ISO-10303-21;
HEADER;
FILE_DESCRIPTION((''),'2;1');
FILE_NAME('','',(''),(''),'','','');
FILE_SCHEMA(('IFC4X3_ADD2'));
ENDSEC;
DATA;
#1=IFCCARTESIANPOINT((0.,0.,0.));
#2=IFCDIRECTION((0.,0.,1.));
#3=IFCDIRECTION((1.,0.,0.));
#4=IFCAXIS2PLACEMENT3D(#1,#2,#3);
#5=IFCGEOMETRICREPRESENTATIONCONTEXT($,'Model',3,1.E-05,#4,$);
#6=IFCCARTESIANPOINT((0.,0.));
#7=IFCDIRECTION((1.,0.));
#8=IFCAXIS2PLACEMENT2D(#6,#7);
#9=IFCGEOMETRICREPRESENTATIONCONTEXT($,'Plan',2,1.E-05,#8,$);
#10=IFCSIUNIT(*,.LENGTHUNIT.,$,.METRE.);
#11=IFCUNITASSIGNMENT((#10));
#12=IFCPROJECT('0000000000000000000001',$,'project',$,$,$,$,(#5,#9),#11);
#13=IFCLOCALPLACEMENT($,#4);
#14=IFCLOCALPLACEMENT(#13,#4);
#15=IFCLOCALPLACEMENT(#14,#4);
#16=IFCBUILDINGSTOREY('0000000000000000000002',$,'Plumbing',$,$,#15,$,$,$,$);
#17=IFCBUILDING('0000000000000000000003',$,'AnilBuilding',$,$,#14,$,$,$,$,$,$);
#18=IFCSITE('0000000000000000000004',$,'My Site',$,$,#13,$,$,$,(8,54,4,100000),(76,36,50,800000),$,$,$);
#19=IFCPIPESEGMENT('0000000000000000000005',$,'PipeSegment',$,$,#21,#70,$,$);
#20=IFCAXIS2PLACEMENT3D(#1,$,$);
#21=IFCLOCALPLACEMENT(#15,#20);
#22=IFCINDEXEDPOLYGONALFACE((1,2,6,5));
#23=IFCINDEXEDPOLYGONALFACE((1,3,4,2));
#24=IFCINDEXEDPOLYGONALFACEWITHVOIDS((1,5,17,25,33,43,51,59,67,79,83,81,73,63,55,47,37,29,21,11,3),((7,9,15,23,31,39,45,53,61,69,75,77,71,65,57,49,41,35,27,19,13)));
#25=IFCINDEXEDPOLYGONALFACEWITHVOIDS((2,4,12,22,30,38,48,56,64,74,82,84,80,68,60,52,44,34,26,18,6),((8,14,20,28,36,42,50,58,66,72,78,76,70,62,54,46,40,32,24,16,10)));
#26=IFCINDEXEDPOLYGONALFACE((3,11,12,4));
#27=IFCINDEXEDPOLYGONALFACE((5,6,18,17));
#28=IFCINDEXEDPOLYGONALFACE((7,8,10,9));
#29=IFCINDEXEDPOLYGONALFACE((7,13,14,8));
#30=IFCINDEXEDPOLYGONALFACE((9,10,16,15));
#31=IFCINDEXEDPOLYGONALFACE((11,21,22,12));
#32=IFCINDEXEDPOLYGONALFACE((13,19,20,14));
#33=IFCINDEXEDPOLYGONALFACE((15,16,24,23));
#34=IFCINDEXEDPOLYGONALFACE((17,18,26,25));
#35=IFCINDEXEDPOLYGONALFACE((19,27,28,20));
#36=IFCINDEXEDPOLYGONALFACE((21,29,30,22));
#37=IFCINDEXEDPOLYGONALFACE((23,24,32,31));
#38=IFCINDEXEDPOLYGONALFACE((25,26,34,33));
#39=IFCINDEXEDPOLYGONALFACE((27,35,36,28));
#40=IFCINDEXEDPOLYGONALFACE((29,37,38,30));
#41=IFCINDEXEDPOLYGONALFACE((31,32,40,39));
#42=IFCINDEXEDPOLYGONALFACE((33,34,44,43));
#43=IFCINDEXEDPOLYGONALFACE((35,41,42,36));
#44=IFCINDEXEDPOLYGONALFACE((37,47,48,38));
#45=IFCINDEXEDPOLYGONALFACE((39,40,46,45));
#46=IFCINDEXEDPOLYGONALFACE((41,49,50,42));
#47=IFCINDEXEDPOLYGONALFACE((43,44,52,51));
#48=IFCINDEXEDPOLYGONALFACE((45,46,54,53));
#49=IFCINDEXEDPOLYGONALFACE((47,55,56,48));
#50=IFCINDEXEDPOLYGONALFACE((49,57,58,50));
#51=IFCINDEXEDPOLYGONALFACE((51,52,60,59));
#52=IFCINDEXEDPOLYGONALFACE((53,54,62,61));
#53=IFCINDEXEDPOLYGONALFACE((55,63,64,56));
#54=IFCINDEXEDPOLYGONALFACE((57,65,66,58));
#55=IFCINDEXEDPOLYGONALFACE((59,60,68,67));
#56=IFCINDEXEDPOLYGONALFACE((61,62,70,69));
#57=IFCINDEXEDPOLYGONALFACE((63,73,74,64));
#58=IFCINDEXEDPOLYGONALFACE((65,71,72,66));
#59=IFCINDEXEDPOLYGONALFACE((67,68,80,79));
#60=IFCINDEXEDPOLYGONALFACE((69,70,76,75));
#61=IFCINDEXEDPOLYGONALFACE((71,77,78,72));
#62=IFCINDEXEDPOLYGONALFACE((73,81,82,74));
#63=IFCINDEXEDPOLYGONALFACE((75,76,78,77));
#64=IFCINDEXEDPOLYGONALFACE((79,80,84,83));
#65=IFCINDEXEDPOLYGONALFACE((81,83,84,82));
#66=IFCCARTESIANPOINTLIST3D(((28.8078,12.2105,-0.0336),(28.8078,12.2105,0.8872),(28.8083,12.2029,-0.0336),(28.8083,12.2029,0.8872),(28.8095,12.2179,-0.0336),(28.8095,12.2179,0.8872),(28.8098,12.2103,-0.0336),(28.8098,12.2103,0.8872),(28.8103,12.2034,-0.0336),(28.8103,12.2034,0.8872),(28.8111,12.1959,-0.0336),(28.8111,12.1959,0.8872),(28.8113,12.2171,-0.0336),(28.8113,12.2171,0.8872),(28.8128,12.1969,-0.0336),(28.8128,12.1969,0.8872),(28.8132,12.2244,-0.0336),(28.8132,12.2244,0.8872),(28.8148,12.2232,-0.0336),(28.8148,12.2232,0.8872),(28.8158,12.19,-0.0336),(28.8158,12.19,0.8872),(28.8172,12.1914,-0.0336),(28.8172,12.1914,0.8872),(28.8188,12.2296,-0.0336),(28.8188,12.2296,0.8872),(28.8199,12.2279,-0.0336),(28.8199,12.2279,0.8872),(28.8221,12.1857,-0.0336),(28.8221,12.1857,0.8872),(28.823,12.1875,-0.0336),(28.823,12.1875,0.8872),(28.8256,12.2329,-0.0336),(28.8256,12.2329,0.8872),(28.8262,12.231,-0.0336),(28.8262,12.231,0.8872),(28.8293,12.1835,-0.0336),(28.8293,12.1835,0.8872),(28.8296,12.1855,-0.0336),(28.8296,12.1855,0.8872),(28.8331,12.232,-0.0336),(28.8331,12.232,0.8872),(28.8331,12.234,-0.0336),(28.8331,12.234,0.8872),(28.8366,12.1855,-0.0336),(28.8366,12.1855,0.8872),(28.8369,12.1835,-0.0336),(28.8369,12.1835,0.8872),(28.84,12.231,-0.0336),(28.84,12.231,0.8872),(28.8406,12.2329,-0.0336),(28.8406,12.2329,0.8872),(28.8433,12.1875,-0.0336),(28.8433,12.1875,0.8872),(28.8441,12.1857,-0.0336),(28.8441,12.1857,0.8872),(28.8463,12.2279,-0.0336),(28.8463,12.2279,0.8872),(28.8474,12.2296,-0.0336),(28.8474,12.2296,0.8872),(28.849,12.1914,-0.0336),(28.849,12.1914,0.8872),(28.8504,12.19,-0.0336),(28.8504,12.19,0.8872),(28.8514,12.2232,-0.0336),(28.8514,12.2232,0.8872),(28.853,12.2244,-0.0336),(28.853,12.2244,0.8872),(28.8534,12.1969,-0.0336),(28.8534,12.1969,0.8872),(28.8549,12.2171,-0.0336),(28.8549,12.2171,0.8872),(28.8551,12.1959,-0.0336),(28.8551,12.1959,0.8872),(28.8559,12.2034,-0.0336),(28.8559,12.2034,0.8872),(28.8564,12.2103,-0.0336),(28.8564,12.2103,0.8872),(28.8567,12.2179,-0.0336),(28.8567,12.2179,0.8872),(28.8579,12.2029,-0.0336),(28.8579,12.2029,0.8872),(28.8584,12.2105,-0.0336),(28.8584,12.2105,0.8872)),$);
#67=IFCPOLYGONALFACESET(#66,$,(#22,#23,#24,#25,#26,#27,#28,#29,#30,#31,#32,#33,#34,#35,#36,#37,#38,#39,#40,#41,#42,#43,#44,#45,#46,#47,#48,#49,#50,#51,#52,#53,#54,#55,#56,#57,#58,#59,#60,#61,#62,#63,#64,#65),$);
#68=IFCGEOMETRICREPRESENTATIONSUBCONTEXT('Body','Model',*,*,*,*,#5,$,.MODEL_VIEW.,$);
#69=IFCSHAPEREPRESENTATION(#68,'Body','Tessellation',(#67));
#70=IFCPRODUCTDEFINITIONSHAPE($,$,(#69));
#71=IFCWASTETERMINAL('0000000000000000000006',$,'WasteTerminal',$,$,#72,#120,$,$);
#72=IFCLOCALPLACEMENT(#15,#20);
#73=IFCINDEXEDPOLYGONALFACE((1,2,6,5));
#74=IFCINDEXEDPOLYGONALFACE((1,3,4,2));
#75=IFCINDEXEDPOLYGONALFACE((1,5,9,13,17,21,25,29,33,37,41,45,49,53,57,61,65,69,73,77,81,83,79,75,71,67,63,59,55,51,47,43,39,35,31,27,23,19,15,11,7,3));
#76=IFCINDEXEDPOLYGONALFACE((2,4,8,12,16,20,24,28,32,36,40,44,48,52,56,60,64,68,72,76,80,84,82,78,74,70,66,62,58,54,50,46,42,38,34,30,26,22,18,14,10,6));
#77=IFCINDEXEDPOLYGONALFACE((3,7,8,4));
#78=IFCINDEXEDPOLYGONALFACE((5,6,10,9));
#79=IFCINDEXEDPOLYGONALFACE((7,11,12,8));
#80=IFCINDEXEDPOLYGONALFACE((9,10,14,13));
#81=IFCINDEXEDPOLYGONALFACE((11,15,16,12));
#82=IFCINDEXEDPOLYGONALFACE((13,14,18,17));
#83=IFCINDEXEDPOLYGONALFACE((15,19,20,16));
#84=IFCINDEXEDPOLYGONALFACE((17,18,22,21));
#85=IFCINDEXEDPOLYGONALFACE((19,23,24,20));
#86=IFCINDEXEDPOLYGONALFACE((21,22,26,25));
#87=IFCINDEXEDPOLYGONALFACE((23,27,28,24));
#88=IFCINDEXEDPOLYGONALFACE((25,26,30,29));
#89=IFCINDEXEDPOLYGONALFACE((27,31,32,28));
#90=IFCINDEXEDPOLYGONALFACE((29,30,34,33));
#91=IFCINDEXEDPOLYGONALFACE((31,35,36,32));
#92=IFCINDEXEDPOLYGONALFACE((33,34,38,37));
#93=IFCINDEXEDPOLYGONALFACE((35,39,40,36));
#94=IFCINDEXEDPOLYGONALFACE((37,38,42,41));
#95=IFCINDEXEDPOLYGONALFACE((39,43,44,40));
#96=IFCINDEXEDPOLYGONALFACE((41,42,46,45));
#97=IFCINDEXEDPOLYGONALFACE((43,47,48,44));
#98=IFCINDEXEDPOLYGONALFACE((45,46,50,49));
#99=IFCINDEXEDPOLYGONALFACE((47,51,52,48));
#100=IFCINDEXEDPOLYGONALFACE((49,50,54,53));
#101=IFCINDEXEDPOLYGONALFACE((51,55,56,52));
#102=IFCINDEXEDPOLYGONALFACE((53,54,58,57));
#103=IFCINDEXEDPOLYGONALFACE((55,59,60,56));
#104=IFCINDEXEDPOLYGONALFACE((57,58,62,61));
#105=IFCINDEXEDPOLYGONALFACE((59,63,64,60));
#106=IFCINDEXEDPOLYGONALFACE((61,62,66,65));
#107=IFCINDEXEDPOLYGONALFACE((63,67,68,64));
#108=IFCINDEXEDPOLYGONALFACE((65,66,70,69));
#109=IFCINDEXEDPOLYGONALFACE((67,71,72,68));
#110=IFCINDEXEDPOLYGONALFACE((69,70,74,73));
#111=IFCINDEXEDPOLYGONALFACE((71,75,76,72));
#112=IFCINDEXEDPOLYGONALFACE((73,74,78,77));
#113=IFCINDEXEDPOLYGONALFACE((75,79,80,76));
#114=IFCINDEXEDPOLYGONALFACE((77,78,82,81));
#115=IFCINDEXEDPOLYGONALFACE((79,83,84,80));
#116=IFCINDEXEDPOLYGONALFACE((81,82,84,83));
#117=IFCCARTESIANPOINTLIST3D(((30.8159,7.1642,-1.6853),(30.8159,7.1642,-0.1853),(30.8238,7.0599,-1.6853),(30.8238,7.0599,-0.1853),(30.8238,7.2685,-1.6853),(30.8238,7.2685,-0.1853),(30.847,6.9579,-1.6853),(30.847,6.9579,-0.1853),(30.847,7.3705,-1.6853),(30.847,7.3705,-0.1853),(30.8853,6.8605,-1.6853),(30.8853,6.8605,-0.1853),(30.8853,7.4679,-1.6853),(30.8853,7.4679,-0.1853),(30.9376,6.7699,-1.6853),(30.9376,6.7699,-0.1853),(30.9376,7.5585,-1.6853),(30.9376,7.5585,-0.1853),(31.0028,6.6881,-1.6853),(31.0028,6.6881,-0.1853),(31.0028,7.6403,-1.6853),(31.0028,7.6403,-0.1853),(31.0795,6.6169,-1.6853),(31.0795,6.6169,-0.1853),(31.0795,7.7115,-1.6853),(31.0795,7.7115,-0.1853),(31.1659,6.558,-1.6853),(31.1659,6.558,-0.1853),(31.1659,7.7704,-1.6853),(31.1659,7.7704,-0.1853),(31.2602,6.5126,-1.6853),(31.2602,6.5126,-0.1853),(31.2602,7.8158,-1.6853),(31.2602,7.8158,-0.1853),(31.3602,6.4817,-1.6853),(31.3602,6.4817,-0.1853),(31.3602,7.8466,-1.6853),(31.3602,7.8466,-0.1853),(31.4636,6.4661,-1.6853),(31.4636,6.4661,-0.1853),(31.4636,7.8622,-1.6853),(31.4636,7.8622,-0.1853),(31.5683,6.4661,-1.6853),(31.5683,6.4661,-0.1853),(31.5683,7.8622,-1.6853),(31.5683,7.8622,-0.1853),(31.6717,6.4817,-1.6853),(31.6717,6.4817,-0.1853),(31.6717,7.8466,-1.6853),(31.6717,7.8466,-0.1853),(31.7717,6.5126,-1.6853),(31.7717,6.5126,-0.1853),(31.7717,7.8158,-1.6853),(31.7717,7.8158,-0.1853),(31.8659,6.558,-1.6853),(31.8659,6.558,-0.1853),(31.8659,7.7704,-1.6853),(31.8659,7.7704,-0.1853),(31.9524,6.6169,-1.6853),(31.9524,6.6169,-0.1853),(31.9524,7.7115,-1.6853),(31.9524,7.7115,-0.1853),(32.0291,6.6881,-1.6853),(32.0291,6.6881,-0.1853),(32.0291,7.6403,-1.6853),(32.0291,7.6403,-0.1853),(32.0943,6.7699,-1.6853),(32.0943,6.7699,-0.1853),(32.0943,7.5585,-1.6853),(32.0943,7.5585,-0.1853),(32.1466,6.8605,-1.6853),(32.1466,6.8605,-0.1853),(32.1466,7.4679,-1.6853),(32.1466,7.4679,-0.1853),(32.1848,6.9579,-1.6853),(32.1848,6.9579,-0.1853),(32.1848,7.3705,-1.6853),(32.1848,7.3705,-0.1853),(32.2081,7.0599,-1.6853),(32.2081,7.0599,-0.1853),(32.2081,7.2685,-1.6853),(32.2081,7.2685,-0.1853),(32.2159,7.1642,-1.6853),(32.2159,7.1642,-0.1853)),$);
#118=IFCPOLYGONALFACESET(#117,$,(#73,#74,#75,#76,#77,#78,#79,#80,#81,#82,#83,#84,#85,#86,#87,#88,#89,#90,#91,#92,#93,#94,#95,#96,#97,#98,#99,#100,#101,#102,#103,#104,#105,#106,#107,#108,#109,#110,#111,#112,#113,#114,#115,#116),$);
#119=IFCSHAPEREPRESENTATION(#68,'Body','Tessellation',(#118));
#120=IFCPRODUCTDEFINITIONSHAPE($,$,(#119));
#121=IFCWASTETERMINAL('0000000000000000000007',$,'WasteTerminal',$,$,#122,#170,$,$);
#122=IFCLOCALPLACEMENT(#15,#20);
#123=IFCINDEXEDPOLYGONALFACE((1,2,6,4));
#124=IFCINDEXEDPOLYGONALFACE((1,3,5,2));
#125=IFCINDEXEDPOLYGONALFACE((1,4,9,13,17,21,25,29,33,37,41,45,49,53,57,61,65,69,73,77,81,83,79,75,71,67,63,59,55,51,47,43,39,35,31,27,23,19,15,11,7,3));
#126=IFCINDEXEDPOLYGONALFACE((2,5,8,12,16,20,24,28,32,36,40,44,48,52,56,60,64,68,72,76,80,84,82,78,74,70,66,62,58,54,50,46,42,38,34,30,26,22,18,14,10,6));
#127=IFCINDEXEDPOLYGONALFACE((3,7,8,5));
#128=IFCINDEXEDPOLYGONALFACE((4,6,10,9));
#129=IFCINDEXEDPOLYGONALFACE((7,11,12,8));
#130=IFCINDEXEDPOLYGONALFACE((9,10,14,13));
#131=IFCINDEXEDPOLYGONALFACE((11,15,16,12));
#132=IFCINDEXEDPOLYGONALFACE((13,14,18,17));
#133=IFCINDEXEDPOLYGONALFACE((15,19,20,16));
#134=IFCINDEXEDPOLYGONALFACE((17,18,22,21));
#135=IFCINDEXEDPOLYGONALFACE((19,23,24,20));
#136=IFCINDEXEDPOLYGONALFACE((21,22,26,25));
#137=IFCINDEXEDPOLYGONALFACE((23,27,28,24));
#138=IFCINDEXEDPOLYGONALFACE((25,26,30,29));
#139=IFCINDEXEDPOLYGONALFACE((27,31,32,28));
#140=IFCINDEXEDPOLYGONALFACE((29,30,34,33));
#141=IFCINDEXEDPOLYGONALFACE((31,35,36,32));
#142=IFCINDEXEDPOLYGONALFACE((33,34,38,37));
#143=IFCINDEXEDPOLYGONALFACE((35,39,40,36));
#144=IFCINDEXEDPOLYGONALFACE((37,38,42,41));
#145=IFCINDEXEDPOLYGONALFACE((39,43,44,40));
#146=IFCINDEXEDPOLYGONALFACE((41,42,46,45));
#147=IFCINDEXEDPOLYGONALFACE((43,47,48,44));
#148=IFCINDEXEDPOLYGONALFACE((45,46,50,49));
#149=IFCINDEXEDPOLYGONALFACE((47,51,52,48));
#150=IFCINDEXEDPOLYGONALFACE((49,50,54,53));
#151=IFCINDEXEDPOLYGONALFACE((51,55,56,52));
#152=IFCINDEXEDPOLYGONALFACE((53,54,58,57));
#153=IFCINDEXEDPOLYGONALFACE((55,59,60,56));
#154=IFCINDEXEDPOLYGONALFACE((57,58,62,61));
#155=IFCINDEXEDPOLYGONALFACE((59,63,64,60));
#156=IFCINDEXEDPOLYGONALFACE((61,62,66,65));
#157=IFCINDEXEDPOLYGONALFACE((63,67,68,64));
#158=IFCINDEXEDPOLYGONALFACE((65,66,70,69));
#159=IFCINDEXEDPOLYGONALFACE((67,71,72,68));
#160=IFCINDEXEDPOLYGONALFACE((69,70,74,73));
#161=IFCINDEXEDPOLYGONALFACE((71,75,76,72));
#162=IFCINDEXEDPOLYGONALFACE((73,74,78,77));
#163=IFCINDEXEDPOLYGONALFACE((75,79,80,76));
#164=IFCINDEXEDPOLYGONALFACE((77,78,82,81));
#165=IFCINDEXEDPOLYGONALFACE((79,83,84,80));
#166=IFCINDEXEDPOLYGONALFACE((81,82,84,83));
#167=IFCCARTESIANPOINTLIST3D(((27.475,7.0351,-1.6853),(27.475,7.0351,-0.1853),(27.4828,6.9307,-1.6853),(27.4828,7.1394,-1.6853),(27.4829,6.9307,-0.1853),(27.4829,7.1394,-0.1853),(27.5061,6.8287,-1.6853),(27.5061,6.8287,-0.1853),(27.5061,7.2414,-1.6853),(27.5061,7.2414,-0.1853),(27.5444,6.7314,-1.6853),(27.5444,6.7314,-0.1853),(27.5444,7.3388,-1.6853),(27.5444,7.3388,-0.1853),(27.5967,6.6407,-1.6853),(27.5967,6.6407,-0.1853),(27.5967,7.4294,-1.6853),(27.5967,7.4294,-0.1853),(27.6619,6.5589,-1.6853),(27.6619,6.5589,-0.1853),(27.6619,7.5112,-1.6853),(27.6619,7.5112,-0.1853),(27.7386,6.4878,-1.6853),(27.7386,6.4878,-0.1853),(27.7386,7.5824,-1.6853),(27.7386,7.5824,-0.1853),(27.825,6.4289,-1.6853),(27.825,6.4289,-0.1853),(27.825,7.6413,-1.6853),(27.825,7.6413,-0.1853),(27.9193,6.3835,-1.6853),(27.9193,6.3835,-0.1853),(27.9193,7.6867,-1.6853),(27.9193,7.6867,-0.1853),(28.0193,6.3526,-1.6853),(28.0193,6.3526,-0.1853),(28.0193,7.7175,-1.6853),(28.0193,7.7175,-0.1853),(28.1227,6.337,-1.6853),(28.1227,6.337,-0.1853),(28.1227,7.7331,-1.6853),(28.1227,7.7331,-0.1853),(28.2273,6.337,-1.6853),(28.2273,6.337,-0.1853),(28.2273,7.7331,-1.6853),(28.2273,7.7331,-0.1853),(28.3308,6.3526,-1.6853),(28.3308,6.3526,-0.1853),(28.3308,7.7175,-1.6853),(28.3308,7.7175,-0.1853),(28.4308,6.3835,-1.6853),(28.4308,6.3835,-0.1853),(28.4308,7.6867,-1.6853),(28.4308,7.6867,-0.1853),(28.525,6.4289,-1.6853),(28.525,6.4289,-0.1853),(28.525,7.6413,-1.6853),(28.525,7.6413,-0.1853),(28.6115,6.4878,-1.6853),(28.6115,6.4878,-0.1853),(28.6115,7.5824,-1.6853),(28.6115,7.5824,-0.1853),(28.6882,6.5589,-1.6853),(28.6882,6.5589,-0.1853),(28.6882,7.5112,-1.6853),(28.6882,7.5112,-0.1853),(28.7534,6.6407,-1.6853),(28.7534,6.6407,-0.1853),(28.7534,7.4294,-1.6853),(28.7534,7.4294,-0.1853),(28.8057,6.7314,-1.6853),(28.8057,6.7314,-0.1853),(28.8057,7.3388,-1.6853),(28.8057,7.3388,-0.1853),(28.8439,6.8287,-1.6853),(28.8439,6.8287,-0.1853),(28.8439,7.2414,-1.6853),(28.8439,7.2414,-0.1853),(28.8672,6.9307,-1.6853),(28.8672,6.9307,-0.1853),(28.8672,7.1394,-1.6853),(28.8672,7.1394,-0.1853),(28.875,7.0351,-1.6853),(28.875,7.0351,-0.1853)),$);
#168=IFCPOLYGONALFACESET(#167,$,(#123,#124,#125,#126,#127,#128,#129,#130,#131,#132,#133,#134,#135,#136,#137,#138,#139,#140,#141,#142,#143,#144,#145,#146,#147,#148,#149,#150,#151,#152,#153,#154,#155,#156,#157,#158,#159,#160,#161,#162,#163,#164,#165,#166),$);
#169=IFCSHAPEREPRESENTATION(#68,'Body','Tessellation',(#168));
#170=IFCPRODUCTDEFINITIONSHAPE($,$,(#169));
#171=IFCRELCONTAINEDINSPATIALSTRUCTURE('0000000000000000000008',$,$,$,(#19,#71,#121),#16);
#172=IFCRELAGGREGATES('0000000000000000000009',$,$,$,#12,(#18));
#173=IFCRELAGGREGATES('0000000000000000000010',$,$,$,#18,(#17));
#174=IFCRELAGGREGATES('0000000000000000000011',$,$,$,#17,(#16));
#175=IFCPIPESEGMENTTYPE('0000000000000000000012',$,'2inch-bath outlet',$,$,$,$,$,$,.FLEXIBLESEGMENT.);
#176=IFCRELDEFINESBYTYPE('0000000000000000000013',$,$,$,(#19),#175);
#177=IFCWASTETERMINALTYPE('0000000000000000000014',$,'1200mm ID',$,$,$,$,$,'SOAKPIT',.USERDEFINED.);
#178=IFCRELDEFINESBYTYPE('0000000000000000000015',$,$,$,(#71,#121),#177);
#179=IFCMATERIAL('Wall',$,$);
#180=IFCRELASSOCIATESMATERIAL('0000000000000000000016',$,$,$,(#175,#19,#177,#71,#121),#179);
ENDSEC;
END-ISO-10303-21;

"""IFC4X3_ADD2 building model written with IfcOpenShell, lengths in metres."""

from ifc_helpers import new_model, si_unit, frame, origin_with_axes, origin_2d_with_axis, place, context, subcontext, project, spatial, circle, hollow_circle, extrude, material, material_profile, profile_set, profile_usage, type_object, element, save


model = new_model("IFC4X3_ADD2")

# Units and contexts
model_context = context("Model", 3, precision=1e-05, world=origin_with_axes())
plan_context = context("Plan", 2, precision=1e-05, world=origin_2d_with_axis())
body_context = subcontext(model_context, "Body", "Model", "MODEL_VIEW")
ifc_project = project(units=[si_unit("LENGTHUNIT", "METRE")], contexts=[model_context, plan_context])

# Site, building, storey
site_placement = place(None, origin_with_axes())
site = spatial("IfcSite", under=ifc_project, at=site_placement, Name="My Site", RefLatitude=(8, 54, 4, 100000), RefLongitude=(76, 36, 50, 800000))
building_placement = place(site_placement, origin_with_axes())
building = spatial("IfcBuilding", under=site, at=building_placement, Name="AnilBuilding")
storey_placement = place(building_placement, origin_with_axes())
storey = spatial("IfcBuildingStorey", under=building, at=storey_placement, Name="Plumbing")

# Pipe segment
ifc_material_1 = material(Name="Wall")
ifc_material_profile_1 = material_profile(ifc_material_1, hollow_circle(Radius=0.0254, WallThickness=0.002))
ifc_profile_set_1 = profile_set([ifc_material_profile_1], Name="graywater")
pipe_segment_type_1 = type_object("IfcPipeSegmentType", Name="2inch-bath outlet", PredefinedType="FLEXIBLESEGMENT", material=ifc_profile_set_1)
ifc_profile_usage_1 = profile_usage(ifc_profile_set_1, cardinal=5)
pipe_segment_1_placement = place(storey_placement, frame((28.8331, 12.2086, -0.0336), z_axis=(0.0, 0.0, 1.0), x_axis=(0.0, 1.0, 0.0)))
element("IfcPipeSegment", 1, at=pipe_segment_1_placement, inside=storey, type_object=pipe_segment_type_1, material=ifc_profile_usage_1, Name="PipeSegment", context=body_context, shape_type="SweptSolid", body=[
    extrude(hollow_circle(Radius=0.0254, WallThickness=0.002), origin_with_axes(), (0.0, 0.0, 1.0), 0.9207),
])

# Waste terminals
ifc_material_profile_2 = material_profile(ifc_material_1, circle(Radius=0.7))
ifc_profile_set_2 = profile_set([ifc_material_profile_2])
ifc_profile_usage_2 = profile_usage(ifc_profile_set_2, cardinal=5)
waste_terminal_type = type_object("IfcWasteTerminalType", Name="1200mm ID", ElementType="SOAKPIT", PredefinedType="USERDEFINED", material=ifc_profile_set_2)
waste_terminal_1_placement = place(storey_placement, frame((31.5159, 7.1642, -0.1853), z_axis=(0.0, 0.0, -1.0), x_axis=(-1.0, 0.0, 0.0)))
element("IfcWasteTerminal", 2, at=waste_terminal_1_placement, inside=storey, type_object=waste_terminal_type, material=ifc_profile_usage_2, Name="WasteTerminal", context=body_context, shape_type="SweptSolid", body=[
    extrude(circle(Radius=0.7), origin_with_axes(), (0.0, 0.0, 1.0), 1.5),
])
ifc_profile_usage_3 = profile_usage(ifc_profile_set_2, cardinal=5)
waste_terminal_2_placement = place(storey_placement, frame((28.175, 7.0351, -0.1853), z_axis=(0.0, 0.0, -1.0), x_axis=(-1.0, 0.0, 0.0)))
element("IfcWasteTerminal", 3, at=waste_terminal_2_placement, inside=storey, type_object=waste_terminal_type, material=ifc_profile_usage_3, Name="WasteTerminal", context=body_context, shape_type="SweptSolid", body=[
    extrude(circle(Radius=0.7), origin_with_axes(), (0.0, 0.0, 1.0), 1.5),
])

save(model, "model.ifc")
